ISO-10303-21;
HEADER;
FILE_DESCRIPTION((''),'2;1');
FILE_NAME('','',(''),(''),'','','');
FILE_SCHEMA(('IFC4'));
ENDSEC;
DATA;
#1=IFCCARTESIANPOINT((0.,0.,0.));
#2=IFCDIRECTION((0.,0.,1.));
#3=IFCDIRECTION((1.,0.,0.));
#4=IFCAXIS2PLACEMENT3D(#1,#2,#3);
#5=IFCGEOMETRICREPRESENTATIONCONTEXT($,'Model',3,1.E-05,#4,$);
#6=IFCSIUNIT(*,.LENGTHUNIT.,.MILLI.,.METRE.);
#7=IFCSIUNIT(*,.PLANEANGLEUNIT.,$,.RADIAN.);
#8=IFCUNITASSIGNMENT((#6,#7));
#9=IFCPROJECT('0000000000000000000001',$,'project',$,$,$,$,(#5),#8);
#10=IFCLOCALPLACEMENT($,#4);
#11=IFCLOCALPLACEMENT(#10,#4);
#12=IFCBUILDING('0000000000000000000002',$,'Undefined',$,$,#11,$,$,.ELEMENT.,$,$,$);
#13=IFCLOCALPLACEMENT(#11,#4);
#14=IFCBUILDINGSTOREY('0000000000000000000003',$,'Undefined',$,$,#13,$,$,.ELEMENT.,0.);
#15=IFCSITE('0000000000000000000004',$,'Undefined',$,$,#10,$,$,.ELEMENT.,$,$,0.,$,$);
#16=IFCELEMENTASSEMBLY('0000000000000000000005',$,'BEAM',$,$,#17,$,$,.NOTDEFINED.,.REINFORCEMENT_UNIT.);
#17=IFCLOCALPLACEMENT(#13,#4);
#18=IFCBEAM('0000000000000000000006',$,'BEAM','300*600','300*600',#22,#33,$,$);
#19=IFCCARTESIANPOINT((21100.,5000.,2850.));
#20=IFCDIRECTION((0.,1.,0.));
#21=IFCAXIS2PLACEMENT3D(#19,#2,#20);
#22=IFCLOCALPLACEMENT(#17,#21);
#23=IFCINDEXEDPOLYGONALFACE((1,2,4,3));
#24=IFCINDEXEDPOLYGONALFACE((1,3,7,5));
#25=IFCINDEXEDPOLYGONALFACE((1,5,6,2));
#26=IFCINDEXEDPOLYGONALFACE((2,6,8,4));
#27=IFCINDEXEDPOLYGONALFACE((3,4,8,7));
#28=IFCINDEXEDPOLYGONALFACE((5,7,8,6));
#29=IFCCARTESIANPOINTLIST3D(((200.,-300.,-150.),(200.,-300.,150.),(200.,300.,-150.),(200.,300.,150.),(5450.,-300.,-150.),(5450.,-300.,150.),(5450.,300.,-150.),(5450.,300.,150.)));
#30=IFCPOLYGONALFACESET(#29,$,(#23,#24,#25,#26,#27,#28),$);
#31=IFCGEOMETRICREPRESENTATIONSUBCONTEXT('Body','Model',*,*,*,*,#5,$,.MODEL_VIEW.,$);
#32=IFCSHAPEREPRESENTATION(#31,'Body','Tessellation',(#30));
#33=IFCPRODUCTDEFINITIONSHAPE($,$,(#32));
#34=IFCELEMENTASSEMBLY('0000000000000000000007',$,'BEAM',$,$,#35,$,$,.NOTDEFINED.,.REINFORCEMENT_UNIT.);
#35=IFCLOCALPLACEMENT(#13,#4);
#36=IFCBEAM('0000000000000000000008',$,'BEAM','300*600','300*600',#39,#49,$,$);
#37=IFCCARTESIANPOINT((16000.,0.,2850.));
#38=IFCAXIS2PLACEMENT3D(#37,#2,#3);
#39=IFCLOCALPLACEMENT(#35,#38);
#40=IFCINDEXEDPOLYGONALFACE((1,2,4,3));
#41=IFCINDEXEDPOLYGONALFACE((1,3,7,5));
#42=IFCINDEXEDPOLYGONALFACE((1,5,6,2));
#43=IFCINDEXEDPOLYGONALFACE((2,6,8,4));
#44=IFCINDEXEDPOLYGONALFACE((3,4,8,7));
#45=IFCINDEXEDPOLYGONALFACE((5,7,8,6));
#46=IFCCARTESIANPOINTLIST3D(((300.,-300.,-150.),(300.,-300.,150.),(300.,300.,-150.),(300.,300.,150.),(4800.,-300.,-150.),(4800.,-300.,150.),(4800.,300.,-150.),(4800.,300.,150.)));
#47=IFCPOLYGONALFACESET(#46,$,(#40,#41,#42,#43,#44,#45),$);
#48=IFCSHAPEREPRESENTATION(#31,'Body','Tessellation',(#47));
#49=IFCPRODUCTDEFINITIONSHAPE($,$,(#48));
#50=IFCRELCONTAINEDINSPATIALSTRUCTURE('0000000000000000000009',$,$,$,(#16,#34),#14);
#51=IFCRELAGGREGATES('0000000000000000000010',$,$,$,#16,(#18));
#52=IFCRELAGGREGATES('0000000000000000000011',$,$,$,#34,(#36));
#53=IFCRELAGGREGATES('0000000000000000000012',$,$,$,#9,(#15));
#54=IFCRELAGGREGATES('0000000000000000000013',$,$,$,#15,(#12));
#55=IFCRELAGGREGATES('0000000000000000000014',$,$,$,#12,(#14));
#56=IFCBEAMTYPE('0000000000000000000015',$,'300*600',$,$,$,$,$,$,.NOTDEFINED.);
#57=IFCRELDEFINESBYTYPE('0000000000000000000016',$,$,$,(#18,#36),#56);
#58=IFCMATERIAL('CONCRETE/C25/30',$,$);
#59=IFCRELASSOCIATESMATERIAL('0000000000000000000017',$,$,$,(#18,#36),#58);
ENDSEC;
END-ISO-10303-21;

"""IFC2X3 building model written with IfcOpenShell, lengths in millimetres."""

from ifc_helpers import new_model, si_unit, frame, origin_with_axes, origin_2d_with_axis, place, context, subcontext, project, spatial, rectangle, extrude, material, type_object, element, aggregate, save


model = new_model("IFC2X3")

# Units and contexts
model_context = context("Model", 3, precision=1e-05, world=origin_with_axes())
body_context = subcontext(model_context, "Body", "Model", "MODEL_VIEW")
ifc_project = project(units=[si_unit("LENGTHUNIT", "METRE", prefix="MILLI"), si_unit("PLANEANGLEUNIT", "RADIAN")], contexts=[model_context])

# Site, building, storey
site_placement = place(None, origin_with_axes())
site = spatial("IfcSite", under=ifc_project, at=site_placement, Name="Undefined", CompositionType="ELEMENT", RefElevation=0.0)
building_placement = place(site_placement, origin_with_axes())
building = spatial("IfcBuilding", under=site, at=building_placement, Name="Undefined", CompositionType="ELEMENT")
storey_placement = place(building_placement, origin_with_axes())
storey = spatial("IfcBuildingStorey", under=building, at=storey_placement, Name="Undefined", CompositionType="ELEMENT", Elevation=0.0)

# Shared definitions
ifc_material = material(Name="CONCRETE/C25/30")

# Element assemblies, beams
beam_type_1 = type_object("IfcBeamType", Name="300*600", PredefinedType="NOTDEFINED")
assembly_1_placement = place(storey_placement, origin_with_axes())
assembly_1 = element("IfcElementAssembly", 1, at=assembly_1_placement, inside=storey, Name="BEAM", AssemblyPlace="NOTDEFINED", PredefinedType="REINFORCEMENT_UNIT")
beam_1_placement = place(assembly_1_placement, frame((21100.0, 5000.0, 2850.0), z_axis=(0.0, 0.0, 1.0), x_axis=(0.0, 1.0, 0.0)))
beam_1 = element("IfcBeam", 2, at=beam_1_placement, type_object=beam_type_1, material=ifc_material, Name="BEAM", Description="300*600", ObjectType="300*600", context=body_context, shape_type="SweptSolid", body=[
    extrude(rectangle(XDim=600.0, YDim=300.0, at=origin_2d_with_axis()), frame((5450.0, 0.0, 0.0), z_axis=(-1.0, 0.0, 0.0), x_axis=(0.0, -1.0, 0.0)), (0.0, 0.0, 1.0), 5250.0),
])
aggregate(assembly_1, [beam_1])
assembly_2_placement = place(storey_placement, origin_with_axes())
assembly_2 = element("IfcElementAssembly", 3, at=assembly_2_placement, inside=storey, Name="BEAM", AssemblyPlace="NOTDEFINED", PredefinedType="REINFORCEMENT_UNIT")
beam_2_placement = place(assembly_2_placement, frame((16000.0, 0.0, 2850.0), z_axis=(0.0, 0.0, 1.0), x_axis=(1.0, 0.0, 0.0)))
beam_2 = element("IfcBeam", 4, at=beam_2_placement, type_object=beam_type_1, material=ifc_material, Name="BEAM", Description="300*600", ObjectType="300*600", context=body_context, shape_type="SweptSolid", body=[
    extrude(rectangle(XDim=600.0, YDim=300.0, at=origin_2d_with_axis()), frame((4800.0, 0.0, 0.0), z_axis=(-1.0, 0.0, 0.0), x_axis=(0.0, -1.0, 0.0)), (0.0, 0.0, 1.0), 4500.0),
])
aggregate(assembly_2, [beam_2])

save(model, "model.ifc")
